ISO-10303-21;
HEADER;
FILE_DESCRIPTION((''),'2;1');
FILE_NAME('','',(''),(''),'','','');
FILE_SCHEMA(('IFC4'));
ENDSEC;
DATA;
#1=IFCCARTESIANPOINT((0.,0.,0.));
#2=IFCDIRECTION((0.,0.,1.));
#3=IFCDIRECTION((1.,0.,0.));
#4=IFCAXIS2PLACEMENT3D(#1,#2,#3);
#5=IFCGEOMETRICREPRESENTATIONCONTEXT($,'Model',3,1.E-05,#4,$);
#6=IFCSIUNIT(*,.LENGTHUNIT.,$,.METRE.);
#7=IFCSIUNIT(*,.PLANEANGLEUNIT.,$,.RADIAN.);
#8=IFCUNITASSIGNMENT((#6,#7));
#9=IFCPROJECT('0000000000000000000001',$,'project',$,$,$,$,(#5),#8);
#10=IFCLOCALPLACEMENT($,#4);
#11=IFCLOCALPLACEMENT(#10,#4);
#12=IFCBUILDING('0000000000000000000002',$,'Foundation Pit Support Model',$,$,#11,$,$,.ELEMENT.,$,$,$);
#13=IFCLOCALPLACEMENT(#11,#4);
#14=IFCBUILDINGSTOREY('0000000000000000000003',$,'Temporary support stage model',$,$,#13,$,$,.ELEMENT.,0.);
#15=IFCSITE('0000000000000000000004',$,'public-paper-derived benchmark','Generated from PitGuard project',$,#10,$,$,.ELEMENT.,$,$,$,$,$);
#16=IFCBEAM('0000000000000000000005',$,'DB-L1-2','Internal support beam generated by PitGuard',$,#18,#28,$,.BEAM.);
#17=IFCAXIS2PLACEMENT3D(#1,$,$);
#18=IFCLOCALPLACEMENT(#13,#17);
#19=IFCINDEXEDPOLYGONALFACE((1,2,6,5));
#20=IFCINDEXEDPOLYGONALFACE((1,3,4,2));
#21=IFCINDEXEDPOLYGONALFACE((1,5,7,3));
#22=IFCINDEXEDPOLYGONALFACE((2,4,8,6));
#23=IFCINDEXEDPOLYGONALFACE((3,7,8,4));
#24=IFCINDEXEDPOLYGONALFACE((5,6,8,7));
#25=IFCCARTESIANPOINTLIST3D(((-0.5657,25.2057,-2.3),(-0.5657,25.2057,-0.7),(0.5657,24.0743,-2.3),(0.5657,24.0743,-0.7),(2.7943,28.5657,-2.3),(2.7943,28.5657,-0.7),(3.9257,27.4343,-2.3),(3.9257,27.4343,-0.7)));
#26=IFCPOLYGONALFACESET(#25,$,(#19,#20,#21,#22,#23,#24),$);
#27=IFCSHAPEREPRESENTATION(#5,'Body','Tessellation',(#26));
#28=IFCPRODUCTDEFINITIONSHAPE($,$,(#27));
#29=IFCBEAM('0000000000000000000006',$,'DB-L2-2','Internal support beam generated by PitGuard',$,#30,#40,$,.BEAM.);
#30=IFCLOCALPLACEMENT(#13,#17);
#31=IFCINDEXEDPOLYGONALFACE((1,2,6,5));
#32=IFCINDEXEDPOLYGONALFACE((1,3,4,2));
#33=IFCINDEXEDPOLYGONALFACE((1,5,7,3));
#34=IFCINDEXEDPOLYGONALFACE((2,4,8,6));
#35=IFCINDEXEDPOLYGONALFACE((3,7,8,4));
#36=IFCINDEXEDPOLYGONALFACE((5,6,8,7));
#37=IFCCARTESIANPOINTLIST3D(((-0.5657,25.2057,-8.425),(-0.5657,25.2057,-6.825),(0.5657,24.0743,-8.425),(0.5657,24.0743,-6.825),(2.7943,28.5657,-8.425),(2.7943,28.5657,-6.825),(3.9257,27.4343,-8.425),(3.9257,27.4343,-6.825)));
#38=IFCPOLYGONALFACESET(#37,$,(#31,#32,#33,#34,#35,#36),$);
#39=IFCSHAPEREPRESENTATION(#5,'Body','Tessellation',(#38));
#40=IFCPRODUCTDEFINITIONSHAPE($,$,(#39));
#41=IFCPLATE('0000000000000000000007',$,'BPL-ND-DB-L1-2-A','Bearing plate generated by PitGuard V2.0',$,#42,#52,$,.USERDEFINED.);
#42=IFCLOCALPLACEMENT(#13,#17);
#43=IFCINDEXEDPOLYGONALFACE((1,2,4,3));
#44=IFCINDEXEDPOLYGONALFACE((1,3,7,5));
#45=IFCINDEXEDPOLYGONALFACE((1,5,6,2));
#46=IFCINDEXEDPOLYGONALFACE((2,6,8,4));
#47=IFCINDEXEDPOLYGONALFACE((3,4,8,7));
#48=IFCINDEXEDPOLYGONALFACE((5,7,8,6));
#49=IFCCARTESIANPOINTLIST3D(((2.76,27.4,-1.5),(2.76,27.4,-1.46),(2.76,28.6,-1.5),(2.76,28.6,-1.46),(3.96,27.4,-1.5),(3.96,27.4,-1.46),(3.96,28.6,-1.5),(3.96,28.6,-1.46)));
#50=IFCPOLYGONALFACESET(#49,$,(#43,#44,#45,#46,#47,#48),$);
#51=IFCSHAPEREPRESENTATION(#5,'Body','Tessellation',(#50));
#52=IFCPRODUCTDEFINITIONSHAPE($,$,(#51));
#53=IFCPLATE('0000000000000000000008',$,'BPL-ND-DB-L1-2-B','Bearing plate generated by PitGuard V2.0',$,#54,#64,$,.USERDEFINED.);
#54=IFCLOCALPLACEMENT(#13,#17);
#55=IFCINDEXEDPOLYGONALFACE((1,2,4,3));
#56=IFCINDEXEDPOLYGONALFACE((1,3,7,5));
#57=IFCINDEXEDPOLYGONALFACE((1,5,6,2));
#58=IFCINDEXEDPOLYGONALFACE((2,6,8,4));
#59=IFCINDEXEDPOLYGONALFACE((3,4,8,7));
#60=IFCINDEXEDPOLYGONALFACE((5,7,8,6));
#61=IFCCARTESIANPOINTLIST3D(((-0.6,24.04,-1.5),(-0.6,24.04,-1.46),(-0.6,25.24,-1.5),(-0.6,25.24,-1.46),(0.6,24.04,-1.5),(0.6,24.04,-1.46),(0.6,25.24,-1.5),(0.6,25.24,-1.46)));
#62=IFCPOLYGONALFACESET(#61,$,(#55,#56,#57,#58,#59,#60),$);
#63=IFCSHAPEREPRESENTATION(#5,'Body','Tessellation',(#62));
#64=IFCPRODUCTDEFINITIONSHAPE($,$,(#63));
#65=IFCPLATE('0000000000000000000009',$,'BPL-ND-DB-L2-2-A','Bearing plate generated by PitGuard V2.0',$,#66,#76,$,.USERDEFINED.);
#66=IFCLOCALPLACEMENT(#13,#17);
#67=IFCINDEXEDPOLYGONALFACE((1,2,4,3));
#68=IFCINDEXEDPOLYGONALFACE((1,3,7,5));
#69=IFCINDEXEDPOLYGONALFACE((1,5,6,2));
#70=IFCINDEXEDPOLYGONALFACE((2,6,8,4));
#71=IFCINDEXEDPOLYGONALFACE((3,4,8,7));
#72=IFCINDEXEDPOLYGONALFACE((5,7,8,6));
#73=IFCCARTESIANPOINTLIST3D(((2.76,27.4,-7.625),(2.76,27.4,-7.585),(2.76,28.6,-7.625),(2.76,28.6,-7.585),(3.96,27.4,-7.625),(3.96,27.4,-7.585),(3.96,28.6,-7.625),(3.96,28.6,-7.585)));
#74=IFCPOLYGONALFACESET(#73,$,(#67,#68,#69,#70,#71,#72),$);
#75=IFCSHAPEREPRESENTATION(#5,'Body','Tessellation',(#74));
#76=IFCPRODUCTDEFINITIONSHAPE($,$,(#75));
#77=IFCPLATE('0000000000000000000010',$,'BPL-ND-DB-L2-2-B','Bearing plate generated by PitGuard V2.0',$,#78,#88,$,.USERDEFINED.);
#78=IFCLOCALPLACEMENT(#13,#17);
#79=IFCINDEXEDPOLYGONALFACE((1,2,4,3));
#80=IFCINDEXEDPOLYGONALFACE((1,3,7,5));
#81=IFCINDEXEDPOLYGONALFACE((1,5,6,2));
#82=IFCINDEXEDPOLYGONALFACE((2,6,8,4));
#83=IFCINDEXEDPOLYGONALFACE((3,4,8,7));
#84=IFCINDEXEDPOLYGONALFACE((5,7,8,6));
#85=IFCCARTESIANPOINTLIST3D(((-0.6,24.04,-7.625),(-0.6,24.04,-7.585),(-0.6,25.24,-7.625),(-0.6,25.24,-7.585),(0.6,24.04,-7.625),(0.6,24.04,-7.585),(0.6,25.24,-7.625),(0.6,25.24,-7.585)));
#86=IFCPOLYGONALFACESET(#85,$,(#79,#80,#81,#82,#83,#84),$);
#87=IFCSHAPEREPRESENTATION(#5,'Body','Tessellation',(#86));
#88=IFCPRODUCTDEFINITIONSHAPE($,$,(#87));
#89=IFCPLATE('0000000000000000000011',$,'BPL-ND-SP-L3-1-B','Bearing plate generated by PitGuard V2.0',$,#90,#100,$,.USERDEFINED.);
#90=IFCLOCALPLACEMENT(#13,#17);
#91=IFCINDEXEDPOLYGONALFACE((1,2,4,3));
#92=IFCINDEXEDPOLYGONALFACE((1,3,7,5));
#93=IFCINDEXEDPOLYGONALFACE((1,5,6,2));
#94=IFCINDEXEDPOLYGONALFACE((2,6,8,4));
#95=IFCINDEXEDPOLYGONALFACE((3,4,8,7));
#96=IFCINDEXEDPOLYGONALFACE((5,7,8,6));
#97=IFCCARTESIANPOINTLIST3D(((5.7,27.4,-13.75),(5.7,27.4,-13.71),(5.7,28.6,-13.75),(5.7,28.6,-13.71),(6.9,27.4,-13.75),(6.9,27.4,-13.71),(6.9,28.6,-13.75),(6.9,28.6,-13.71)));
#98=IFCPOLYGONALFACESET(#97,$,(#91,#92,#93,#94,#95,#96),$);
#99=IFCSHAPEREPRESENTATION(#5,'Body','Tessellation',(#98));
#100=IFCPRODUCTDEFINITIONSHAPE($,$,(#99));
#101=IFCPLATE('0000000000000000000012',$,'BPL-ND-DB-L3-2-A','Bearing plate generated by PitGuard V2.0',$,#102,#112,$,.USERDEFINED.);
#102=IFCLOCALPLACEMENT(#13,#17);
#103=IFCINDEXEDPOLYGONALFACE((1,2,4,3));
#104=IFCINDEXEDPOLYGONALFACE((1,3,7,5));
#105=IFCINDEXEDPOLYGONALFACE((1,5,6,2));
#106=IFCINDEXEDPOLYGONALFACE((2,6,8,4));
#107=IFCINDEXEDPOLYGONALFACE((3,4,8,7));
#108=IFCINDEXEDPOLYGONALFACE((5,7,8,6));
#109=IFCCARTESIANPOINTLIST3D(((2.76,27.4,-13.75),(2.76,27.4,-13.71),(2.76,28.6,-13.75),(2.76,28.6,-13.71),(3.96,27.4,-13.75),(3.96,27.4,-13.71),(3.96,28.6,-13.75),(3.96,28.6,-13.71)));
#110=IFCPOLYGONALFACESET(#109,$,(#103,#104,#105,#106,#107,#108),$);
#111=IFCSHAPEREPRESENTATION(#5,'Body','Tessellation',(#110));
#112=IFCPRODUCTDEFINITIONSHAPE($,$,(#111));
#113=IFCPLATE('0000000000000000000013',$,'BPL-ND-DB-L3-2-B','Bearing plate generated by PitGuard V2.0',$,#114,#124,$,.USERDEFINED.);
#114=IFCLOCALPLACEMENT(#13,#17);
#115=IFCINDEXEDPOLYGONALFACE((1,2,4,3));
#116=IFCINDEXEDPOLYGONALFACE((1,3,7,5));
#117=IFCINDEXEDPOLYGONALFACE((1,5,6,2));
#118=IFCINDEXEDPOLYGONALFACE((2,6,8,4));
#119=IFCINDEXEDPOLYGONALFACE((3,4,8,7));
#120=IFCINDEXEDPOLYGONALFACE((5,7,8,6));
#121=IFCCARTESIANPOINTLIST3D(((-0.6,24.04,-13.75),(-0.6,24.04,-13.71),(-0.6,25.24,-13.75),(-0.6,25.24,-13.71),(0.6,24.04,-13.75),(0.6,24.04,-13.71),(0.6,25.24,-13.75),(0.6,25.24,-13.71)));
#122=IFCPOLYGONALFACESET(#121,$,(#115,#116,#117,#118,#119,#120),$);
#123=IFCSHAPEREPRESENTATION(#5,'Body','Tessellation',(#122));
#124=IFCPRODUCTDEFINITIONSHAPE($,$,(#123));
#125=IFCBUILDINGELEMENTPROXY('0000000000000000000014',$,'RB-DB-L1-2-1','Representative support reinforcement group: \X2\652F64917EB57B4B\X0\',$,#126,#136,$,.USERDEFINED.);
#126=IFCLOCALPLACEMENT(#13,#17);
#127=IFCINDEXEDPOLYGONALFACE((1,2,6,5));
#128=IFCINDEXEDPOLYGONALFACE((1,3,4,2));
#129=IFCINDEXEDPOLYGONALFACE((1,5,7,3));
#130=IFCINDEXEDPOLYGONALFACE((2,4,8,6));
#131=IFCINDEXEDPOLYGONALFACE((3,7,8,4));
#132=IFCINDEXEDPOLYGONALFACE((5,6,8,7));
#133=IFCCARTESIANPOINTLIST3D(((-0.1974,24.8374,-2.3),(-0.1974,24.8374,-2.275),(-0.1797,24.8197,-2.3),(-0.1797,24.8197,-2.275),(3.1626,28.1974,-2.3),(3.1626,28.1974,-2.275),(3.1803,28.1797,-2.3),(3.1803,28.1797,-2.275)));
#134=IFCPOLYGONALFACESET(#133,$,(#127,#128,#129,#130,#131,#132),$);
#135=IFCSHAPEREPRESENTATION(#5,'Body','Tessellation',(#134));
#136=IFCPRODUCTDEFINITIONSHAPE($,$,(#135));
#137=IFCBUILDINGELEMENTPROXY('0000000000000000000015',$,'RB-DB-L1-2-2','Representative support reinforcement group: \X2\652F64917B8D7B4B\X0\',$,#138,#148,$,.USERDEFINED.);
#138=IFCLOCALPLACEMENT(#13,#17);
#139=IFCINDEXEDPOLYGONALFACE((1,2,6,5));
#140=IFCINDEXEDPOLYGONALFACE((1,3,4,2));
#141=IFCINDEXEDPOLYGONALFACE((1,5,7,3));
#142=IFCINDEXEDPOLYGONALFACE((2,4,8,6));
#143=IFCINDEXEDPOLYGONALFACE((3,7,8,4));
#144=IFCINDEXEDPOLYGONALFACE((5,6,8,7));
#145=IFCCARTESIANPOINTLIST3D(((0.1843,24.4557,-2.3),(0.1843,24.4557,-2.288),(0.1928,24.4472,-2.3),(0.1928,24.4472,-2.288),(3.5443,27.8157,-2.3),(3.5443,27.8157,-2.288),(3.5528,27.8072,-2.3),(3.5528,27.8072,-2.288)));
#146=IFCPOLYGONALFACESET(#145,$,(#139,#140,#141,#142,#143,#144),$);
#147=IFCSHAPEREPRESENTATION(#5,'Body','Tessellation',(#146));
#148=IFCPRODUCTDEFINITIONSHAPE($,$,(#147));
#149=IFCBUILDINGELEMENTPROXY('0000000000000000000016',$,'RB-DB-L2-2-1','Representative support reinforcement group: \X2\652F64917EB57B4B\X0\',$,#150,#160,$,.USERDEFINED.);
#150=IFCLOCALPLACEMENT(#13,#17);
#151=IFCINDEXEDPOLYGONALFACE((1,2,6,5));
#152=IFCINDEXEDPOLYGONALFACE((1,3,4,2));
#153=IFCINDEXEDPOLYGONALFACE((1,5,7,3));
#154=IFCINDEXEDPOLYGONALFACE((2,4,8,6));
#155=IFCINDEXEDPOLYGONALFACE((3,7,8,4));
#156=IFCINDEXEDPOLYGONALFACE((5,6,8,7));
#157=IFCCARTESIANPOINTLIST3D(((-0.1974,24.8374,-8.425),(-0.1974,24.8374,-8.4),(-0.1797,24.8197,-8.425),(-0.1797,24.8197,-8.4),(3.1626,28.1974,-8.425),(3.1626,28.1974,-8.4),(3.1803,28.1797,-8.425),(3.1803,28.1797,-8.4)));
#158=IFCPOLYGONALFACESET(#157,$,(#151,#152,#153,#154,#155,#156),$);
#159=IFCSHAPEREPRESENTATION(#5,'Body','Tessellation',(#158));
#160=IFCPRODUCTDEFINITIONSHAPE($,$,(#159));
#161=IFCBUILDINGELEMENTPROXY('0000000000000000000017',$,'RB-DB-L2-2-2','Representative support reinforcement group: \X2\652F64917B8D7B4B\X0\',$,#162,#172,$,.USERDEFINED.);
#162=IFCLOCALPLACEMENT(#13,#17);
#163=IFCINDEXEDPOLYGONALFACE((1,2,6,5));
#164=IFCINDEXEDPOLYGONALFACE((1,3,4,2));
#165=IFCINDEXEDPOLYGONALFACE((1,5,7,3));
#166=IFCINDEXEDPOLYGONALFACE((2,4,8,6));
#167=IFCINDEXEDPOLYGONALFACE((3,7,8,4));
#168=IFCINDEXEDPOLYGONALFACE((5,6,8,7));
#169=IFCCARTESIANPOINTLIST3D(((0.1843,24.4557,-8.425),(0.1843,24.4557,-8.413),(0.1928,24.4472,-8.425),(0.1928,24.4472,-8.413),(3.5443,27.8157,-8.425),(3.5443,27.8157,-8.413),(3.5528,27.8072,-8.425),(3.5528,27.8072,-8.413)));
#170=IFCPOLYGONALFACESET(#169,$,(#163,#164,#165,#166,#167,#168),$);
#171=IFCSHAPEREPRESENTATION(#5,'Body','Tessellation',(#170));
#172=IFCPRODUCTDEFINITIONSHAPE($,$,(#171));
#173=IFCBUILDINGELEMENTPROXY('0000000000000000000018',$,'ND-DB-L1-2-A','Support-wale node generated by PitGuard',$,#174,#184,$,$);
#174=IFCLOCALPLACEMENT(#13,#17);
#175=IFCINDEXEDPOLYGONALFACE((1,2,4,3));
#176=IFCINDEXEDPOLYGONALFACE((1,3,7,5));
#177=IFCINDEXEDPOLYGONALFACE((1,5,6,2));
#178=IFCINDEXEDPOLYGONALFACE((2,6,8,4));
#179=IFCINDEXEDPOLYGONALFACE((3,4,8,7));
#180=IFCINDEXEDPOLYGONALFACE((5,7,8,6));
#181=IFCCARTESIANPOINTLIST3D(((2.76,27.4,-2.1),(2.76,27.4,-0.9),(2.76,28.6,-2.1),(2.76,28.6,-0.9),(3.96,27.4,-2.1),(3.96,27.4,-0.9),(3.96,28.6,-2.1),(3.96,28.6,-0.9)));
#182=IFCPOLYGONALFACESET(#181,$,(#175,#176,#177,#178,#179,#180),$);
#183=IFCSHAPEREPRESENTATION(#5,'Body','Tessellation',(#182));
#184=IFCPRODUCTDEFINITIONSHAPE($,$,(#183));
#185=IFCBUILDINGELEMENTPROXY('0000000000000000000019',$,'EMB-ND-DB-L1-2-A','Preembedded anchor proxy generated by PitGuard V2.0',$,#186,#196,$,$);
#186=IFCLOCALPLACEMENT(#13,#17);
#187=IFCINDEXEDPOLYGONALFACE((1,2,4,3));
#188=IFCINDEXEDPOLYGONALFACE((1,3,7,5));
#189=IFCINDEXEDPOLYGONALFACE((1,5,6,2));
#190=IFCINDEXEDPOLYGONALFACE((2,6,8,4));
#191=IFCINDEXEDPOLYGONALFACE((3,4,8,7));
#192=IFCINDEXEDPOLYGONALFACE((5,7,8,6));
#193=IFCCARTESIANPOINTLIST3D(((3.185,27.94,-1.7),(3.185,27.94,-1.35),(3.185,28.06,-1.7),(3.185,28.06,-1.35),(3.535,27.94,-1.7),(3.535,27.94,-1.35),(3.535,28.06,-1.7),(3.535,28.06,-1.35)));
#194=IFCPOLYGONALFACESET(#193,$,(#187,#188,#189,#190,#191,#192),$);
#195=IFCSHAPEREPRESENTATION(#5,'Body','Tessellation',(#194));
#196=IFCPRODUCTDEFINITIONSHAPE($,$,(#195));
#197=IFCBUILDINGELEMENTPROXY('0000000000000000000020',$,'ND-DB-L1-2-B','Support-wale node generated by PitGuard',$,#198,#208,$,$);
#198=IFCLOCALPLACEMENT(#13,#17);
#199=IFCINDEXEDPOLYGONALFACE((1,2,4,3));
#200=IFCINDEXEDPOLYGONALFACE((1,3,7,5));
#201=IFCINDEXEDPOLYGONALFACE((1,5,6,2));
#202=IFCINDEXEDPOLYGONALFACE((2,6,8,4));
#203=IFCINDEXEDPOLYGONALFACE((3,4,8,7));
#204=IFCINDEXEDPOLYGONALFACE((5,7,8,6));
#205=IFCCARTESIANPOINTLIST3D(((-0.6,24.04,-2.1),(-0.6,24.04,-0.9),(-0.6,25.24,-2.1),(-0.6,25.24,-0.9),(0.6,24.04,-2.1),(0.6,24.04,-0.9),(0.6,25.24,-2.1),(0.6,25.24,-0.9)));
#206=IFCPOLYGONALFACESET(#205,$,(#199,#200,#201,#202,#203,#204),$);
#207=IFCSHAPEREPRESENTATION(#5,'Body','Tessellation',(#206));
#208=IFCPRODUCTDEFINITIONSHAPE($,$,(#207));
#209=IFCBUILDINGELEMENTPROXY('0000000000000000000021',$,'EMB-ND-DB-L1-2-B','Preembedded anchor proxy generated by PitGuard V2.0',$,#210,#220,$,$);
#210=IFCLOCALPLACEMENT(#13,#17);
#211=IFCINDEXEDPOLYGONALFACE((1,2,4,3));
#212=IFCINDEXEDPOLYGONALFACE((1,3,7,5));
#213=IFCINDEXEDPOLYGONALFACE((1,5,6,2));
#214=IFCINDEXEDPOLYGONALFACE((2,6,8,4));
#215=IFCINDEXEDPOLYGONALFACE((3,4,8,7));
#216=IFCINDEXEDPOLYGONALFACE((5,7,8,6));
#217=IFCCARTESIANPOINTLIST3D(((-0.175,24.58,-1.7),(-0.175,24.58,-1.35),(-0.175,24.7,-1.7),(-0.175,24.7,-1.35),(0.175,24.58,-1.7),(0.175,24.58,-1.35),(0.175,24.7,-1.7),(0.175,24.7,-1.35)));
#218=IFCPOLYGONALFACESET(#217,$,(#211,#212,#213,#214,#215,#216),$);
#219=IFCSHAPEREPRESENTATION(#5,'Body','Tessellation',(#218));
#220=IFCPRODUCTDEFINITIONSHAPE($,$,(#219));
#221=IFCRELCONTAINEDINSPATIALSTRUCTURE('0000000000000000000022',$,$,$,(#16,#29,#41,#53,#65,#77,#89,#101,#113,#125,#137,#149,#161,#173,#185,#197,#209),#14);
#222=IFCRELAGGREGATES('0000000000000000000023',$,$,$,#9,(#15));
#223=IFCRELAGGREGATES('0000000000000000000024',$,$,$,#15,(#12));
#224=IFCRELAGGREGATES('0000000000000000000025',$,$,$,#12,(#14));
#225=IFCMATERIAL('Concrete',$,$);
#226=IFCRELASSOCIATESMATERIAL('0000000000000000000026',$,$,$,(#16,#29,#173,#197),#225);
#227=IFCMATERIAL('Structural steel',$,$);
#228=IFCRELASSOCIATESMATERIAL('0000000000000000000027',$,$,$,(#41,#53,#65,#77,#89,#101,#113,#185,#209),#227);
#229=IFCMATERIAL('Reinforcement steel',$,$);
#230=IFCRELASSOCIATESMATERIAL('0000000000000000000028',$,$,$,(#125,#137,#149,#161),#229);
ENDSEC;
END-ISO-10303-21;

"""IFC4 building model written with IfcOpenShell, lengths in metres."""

from ifc_helpers import new_model, si_unit, frame, origin_with_axes, origin_2d, place, context, project, spatial, rectangle, extrude, material, element, save


model = new_model("IFC4")

# Units and contexts
model_context = context("Model", 3, precision=1e-05, world=origin_with_axes())
ifc_project = project(units=[si_unit("LENGTHUNIT", "METRE"), si_unit("PLANEANGLEUNIT", "RADIAN")], contexts=[model_context])

# Site, building, storey
site_placement = place(None, origin_with_axes())
site = spatial("IfcSite", under=ifc_project, at=site_placement, Name="public-paper-derived benchmark", Description="Generated from PitGuard project", CompositionType="ELEMENT")
building_placement = place(site_placement, origin_with_axes())
building = spatial("IfcBuilding", under=site, at=building_placement, Name="Foundation Pit Support Model", CompositionType="ELEMENT")
storey_placement = place(building_placement, origin_with_axes())
storey = spatial("IfcBuildingStorey", under=building, at=storey_placement, Name="Temporary support stage model", CompositionType="ELEMENT", Elevation=0.0)

# Beams
ifc_material_1 = material(Name="Concrete")
for number, where, z_axis, x_axis, name in (
    (1, (1.68, 26.32, -2.3), (0.0, 0.0, 1.0), (-0.707107, -0.707107, 0.0), "DB-L1-2"),
    (2, (1.68, 26.32, -8.425), (0.0, 0.0, 1.0), (-0.707107, -0.707107, 0.0), "DB-L2-2"),
):
    element("IfcBeam", number, at=place(storey_placement, frame(where, z_axis=z_axis, x_axis=x_axis)), inside=storey, material=ifc_material_1, Name=name, Description="Internal support beam generated by PitGuard", PredefinedType="BEAM", context=model_context, shape_type="SweptSolid", body=[
        extrude(rectangle(XDim=4.7518, YDim=1.6, at=origin_2d()), origin_with_axes(), (0.0, 0.0, 1.0), 1.6),
    ])

# Plates
ifc_material_2 = material(Name="Structural steel")
for number, where, z_axis, x_axis, name in (
    (3, (3.36, 28.0, -1.5), (0.0, 0.0, 1.0), (1.0, 0.0, 0.0), "BPL-ND-DB-L1-2-A"),
    (4, (0.0, 24.64, -1.5), (0.0, 0.0, 1.0), (1.0, 0.0, 0.0), "BPL-ND-DB-L1-2-B"),
    (5, (3.36, 28.0, -7.625), (0.0, 0.0, 1.0), (1.0, 0.0, 0.0), "BPL-ND-DB-L2-2-A"),
    (6, (0.0, 24.64, -7.625), (0.0, 0.0, 1.0), (1.0, 0.0, 0.0), "BPL-ND-DB-L2-2-B"),
    (7, (6.3, 28.0, -13.75), (0.0, 0.0, 1.0), (1.0, 0.0, 0.0), "BPL-ND-SP-L3-1-B"),
    (8, (3.36, 28.0, -13.75), (0.0, 0.0, 1.0), (1.0, 0.0, 0.0), "BPL-ND-DB-L3-2-A"),
    (9, (0.0, 24.64, -13.75), (0.0, 0.0, 1.0), (1.0, 0.0, 0.0), "BPL-ND-DB-L3-2-B"),
):
    element("IfcPlate", number, at=place(storey_placement, frame(where, z_axis=z_axis, x_axis=x_axis)), inside=storey, material=ifc_material_2, Name=name, Description="Bearing plate generated by PitGuard V2.0", PredefinedType="USERDEFINED", context=model_context, shape_type="SweptSolid", body=[
        extrude(rectangle(XDim=1.2, YDim=1.2, at=origin_2d()), origin_with_axes(), (0.0, 0.0, 1.0), 0.04),
    ])

# Building element proxies
ifc_material_3 = material(Name="Reinforcement steel")
proxy_1_placement = place(storey_placement, frame((1.4914, 26.5086, -2.3), z_axis=(0.0, 0.0, 1.0), x_axis=(-0.707107, -0.707107, 0.0)))
element("IfcBuildingElementProxy", 10, at=proxy_1_placement, inside=storey, material=ifc_material_3, Name="RB-DB-L1-2-1", Description="Representative support reinforcement group: 支撑纵筋", PredefinedType="USERDEFINED", context=model_context, shape_type="SweptSolid", body=[
    extrude(rectangle(XDim=4.7518, YDim=0.025, at=origin_2d()), origin_with_axes(), (0.0, 0.0, 1.0), 0.025),
])
proxy_2_placement = place(storey_placement, frame((1.8686, 26.1314, -2.3), z_axis=(0.0, 0.0, 1.0), x_axis=(-0.707107, -0.707107, 0.0)))
element("IfcBuildingElementProxy", 11, at=proxy_2_placement, inside=storey, material=ifc_material_3, Name="RB-DB-L1-2-2", Description="Representative support reinforcement group: 支撑箍筋", PredefinedType="USERDEFINED", context=model_context, shape_type="SweptSolid", body=[
    extrude(rectangle(XDim=4.7518, YDim=0.012, at=origin_2d()), origin_with_axes(), (0.0, 0.0, 1.0), 0.012),
])
proxy_3_placement = place(storey_placement, frame((1.4914, 26.5086, -8.425), z_axis=(0.0, 0.0, 1.0), x_axis=(-0.707107, -0.707107, 0.0)))
element("IfcBuildingElementProxy", 12, at=proxy_3_placement, inside=storey, material=ifc_material_3, Name="RB-DB-L2-2-1", Description="Representative support reinforcement group: 支撑纵筋", PredefinedType="USERDEFINED", context=model_context, shape_type="SweptSolid", body=[
    extrude(rectangle(XDim=4.7518, YDim=0.025, at=origin_2d()), origin_with_axes(), (0.0, 0.0, 1.0), 0.025),
])
proxy_4_placement = place(storey_placement, frame((1.8686, 26.1314, -8.425), z_axis=(0.0, 0.0, 1.0), x_axis=(-0.707107, -0.707107, 0.0)))
element("IfcBuildingElementProxy", 13, at=proxy_4_placement, inside=storey, material=ifc_material_3, Name="RB-DB-L2-2-2", Description="Representative support reinforcement group: 支撑箍筋", PredefinedType="USERDEFINED", context=model_context, shape_type="SweptSolid", body=[
    extrude(rectangle(XDim=4.7518, YDim=0.012, at=origin_2d()), origin_with_axes(), (0.0, 0.0, 1.0), 0.012),
])
proxy_5_placement = place(storey_placement, frame((3.36, 28.0, -2.1), z_axis=(0.0, 0.0, 1.0), x_axis=(1.0, 0.0, 0.0)))
element("IfcBuildingElementProxy", 14, at=proxy_5_placement, inside=storey, material=ifc_material_1, Name="ND-DB-L1-2-A", Description="Support-wale node generated by PitGuard", context=model_context, shape_type="SweptSolid", body=[
    extrude(rectangle(XDim=1.2, YDim=1.2, at=origin_2d()), origin_with_axes(), (0.0, 0.0, 1.0), 1.2),
])
proxy_6_placement = place(storey_placement, frame((3.36, 28.0, -1.7), z_axis=(0.0, 0.0, 1.0), x_axis=(1.0, 0.0, 0.0)))
element("IfcBuildingElementProxy", 15, at=proxy_6_placement, inside=storey, material=ifc_material_2, Name="EMB-ND-DB-L1-2-A", Description="Preembedded anchor proxy generated by PitGuard V2.0", context=model_context, shape_type="SweptSolid", body=[
    extrude(rectangle(XDim=0.35, YDim=0.12, at=origin_2d()), origin_with_axes(), (0.0, 0.0, 1.0), 0.35),
])
proxy_7_placement = place(storey_placement, frame((0.0, 24.64, -2.1), z_axis=(0.0, 0.0, 1.0), x_axis=(1.0, 0.0, 0.0)))
element("IfcBuildingElementProxy", 16, at=proxy_7_placement, inside=storey, material=ifc_material_1, Name="ND-DB-L1-2-B", Description="Support-wale node generated by PitGuard", context=model_context, shape_type="SweptSolid", body=[
    extrude(rectangle(XDim=1.2, YDim=1.2, at=origin_2d()), origin_with_axes(), (0.0, 0.0, 1.0), 1.2),
])
proxy_8_placement = place(storey_placement, frame((0.0, 24.64, -1.7), z_axis=(0.0, 0.0, 1.0), x_axis=(1.0, 0.0, 0.0)))
element("IfcBuildingElementProxy", 17, at=proxy_8_placement, inside=storey, material=ifc_material_2, Name="EMB-ND-DB-L1-2-B", Description="Preembedded anchor proxy generated by PitGuard V2.0", context=model_context, shape_type="SweptSolid", body=[
    extrude(rectangle(XDim=0.35, YDim=0.12, at=origin_2d()), origin_with_axes(), (0.0, 0.0, 1.0), 0.35),
])

save(model, "model.ifc")
